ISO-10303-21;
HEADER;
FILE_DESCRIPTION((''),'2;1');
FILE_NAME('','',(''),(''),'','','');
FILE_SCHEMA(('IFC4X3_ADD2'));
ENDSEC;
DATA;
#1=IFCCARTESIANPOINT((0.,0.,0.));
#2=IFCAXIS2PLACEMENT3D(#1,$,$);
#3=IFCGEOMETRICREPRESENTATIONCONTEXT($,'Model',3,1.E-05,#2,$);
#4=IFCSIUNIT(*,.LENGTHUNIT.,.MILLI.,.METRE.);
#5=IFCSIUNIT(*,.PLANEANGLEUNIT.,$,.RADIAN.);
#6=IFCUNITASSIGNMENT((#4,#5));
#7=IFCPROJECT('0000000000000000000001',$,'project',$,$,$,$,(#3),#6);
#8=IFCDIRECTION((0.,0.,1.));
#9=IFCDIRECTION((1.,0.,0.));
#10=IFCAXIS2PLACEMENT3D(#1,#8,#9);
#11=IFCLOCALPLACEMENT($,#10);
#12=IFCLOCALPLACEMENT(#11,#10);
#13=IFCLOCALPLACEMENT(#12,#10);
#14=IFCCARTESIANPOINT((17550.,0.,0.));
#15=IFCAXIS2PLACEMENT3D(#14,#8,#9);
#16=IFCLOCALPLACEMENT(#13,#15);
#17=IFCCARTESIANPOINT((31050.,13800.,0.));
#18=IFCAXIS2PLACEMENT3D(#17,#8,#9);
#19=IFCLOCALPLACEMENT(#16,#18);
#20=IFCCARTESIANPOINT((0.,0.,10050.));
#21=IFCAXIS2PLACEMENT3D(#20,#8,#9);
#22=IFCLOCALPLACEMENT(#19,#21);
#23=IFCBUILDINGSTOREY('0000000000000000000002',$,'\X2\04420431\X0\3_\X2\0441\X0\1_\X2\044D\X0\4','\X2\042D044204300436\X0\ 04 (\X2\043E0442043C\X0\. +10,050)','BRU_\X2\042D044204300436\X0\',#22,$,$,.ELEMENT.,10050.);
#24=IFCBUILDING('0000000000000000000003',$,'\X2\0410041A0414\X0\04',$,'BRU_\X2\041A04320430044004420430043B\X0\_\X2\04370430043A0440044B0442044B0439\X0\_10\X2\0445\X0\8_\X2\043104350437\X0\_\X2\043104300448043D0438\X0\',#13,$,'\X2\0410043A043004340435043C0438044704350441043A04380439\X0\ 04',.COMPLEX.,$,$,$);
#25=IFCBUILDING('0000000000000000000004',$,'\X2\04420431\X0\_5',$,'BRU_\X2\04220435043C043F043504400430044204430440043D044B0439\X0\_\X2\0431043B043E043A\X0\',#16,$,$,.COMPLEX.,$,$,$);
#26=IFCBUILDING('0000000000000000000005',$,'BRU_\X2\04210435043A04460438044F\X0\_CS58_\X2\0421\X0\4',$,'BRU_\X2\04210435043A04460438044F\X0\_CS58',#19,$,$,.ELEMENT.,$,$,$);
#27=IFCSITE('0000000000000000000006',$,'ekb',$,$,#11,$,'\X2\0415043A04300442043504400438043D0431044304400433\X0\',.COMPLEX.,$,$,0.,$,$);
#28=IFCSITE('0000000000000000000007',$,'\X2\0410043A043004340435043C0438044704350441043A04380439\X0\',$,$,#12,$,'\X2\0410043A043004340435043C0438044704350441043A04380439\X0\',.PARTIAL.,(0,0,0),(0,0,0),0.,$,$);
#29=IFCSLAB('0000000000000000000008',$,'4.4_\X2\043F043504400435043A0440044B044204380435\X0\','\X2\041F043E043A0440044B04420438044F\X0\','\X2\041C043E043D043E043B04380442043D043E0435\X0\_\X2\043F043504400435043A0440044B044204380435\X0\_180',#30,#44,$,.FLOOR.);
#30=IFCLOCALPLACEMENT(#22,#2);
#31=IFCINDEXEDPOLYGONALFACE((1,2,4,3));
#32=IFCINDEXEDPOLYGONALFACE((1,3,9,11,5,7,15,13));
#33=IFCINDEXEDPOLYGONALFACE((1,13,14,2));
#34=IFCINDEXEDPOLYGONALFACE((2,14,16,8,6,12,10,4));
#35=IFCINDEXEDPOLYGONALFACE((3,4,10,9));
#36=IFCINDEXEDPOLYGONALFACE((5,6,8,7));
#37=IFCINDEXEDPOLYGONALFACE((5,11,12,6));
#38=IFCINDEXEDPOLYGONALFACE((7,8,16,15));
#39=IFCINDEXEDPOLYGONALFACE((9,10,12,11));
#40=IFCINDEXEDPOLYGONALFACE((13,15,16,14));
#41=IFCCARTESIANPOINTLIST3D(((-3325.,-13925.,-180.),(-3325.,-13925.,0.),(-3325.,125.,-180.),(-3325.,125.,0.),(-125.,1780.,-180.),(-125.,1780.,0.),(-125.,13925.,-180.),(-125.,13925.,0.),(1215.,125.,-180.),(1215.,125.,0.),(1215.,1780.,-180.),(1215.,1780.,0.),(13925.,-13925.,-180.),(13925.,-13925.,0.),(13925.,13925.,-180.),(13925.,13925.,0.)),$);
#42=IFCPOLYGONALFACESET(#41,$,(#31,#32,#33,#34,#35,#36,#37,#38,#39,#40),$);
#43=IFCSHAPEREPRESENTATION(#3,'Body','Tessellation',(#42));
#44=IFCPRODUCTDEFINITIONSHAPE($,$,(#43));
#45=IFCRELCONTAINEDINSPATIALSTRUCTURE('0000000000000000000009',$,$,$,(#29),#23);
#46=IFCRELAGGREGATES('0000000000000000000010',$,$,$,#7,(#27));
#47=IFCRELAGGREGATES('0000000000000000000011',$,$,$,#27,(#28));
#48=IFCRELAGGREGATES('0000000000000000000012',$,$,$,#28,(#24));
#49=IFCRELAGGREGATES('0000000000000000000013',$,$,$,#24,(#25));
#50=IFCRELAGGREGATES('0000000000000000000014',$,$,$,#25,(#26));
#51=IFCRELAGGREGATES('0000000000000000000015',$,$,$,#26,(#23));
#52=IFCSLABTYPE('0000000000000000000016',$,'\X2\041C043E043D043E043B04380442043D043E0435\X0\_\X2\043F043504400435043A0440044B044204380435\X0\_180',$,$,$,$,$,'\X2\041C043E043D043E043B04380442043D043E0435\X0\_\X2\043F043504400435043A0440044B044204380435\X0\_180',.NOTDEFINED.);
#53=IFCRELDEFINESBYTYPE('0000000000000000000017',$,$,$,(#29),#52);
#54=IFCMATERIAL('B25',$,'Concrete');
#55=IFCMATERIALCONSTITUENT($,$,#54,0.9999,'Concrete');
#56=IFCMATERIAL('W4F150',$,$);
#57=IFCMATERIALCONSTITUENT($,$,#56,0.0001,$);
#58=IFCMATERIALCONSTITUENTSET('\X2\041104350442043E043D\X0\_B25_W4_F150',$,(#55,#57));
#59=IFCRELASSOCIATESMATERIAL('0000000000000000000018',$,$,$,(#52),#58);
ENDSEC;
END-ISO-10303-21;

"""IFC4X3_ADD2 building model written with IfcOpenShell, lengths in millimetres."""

from ifc_helpers import new_model, si_unit, frame, origin, origin_with_axes, place, context, project, spatial, polyline, outline, extrude, material, constituent, constituent_set, type_object, element, save


model = new_model("IFC4X3_ADD2")

# Units and contexts
model_context = context("Model", 3, precision=1e-05, world=origin())
ifc_project = project(units=[si_unit("LENGTHUNIT", "METRE", prefix="MILLI"), si_unit("PLANEANGLEUNIT", "RADIAN")], contexts=[model_context])

# Sites, buildings, storey
site_1_placement = place(None, origin_with_axes())
site_1 = spatial("IfcSite", under=ifc_project, at=site_1_placement, Name="ekb", LongName="Екатеринбург", CompositionType="COMPLEX", RefElevation=0.0)
site_2_placement = place(site_1_placement, origin_with_axes())
site_2 = spatial("IfcSite", under=site_1, at=site_2_placement, Name="Академический", LongName="Академический", CompositionType="PARTIAL", RefLatitude=(0, 0, 0), RefLongitude=(0, 0, 0), RefElevation=0.0)
building_1_placement = place(site_2_placement, origin_with_axes())
building_1 = spatial("IfcBuilding", under=site_2, at=building_1_placement, Name="АКД04", ObjectType="BRU_Квартал_закрытый_10х8_без_башни", LongName="Академический 04", CompositionType="COMPLEX")
building_2_placement = place(building_1_placement, frame((17550.0, 0.0, 0.0), z_axis=(0.0, 0.0, 1.0), x_axis=(1.0, 0.0, 0.0)))
building_2 = spatial("IfcBuilding", under=building_1, at=building_2_placement, Name="тб_5", ObjectType="BRU_Температурный_блок", CompositionType="COMPLEX")
building_3_placement = place(building_2_placement, frame((31050.0, 13800.0, 0.0), z_axis=(0.0, 0.0, 1.0), x_axis=(1.0, 0.0, 0.0)))
building_3 = spatial("IfcBuilding", under=building_2, at=building_3_placement, Name="BRU_Секция_CS58_С4", ObjectType="BRU_Секция_CS58", CompositionType="ELEMENT")
storey_placement = place(building_3_placement, frame((0.0, 0.0, 10050.0), z_axis=(0.0, 0.0, 1.0), x_axis=(1.0, 0.0, 0.0)))
storey = spatial("IfcBuildingStorey", under=building_3, at=storey_placement, Name="тб3_с1_э4", Description="Этаж 04 (отм. +10,050)", ObjectType="BRU_Этаж", CompositionType="ELEMENT", Elevation=10050.0)

# Shared definitions
ifc_material_1 = material(Name="B25", Category="Concrete")
ifc_material_2 = material(Name="W4F150")

# Slab
ifc_constituent_1 = constituent(ifc_material_1, Category="Concrete", fraction=0.9999)
ifc_constituent_2 = constituent(ifc_material_2, fraction=0.0001)
ifc_constituent_set_1 = constituent_set(constituents=[ifc_constituent_1, ifc_constituent_2], Name="Бетон_B25_W4_F150")
slab_type = type_object("IfcSlabType", Name="Монолитное_перекрытие_180", ElementType="Монолитное_перекрытие_180", PredefinedType="NOTDEFINED", material=ifc_constituent_set_1)
slab_placement = place(storey_placement, frame((0.0, 0.0, -180.0), z_axis=(0.0, 0.0, 1.0), x_axis=(1.0, 0.0, 0.0)))
element("IfcSlab", 1, at=slab_placement, inside=storey, type_object=slab_type, Name="4.4_перекрытие", Description="Покрытия", ObjectType="Монолитное_перекрытие_180", PredefinedType="FLOOR", context=model_context, shape_type="SweptSolid", body=[
    extrude(outline(polyline([(13925.0, -13925.0), (13925.0, 13925.0), (-125.0, 13925.0), (-125.0, 1780.0), (1215.0, 1780.0), (1215.0, 125.0), (-3325.0, 125.0), (-3325.0, -13925.0), (13925.0, -13925.0)])), origin_with_axes(), (0.0, 0.0, 1.0), 180.0),
])

save(model, "model.ifc")
